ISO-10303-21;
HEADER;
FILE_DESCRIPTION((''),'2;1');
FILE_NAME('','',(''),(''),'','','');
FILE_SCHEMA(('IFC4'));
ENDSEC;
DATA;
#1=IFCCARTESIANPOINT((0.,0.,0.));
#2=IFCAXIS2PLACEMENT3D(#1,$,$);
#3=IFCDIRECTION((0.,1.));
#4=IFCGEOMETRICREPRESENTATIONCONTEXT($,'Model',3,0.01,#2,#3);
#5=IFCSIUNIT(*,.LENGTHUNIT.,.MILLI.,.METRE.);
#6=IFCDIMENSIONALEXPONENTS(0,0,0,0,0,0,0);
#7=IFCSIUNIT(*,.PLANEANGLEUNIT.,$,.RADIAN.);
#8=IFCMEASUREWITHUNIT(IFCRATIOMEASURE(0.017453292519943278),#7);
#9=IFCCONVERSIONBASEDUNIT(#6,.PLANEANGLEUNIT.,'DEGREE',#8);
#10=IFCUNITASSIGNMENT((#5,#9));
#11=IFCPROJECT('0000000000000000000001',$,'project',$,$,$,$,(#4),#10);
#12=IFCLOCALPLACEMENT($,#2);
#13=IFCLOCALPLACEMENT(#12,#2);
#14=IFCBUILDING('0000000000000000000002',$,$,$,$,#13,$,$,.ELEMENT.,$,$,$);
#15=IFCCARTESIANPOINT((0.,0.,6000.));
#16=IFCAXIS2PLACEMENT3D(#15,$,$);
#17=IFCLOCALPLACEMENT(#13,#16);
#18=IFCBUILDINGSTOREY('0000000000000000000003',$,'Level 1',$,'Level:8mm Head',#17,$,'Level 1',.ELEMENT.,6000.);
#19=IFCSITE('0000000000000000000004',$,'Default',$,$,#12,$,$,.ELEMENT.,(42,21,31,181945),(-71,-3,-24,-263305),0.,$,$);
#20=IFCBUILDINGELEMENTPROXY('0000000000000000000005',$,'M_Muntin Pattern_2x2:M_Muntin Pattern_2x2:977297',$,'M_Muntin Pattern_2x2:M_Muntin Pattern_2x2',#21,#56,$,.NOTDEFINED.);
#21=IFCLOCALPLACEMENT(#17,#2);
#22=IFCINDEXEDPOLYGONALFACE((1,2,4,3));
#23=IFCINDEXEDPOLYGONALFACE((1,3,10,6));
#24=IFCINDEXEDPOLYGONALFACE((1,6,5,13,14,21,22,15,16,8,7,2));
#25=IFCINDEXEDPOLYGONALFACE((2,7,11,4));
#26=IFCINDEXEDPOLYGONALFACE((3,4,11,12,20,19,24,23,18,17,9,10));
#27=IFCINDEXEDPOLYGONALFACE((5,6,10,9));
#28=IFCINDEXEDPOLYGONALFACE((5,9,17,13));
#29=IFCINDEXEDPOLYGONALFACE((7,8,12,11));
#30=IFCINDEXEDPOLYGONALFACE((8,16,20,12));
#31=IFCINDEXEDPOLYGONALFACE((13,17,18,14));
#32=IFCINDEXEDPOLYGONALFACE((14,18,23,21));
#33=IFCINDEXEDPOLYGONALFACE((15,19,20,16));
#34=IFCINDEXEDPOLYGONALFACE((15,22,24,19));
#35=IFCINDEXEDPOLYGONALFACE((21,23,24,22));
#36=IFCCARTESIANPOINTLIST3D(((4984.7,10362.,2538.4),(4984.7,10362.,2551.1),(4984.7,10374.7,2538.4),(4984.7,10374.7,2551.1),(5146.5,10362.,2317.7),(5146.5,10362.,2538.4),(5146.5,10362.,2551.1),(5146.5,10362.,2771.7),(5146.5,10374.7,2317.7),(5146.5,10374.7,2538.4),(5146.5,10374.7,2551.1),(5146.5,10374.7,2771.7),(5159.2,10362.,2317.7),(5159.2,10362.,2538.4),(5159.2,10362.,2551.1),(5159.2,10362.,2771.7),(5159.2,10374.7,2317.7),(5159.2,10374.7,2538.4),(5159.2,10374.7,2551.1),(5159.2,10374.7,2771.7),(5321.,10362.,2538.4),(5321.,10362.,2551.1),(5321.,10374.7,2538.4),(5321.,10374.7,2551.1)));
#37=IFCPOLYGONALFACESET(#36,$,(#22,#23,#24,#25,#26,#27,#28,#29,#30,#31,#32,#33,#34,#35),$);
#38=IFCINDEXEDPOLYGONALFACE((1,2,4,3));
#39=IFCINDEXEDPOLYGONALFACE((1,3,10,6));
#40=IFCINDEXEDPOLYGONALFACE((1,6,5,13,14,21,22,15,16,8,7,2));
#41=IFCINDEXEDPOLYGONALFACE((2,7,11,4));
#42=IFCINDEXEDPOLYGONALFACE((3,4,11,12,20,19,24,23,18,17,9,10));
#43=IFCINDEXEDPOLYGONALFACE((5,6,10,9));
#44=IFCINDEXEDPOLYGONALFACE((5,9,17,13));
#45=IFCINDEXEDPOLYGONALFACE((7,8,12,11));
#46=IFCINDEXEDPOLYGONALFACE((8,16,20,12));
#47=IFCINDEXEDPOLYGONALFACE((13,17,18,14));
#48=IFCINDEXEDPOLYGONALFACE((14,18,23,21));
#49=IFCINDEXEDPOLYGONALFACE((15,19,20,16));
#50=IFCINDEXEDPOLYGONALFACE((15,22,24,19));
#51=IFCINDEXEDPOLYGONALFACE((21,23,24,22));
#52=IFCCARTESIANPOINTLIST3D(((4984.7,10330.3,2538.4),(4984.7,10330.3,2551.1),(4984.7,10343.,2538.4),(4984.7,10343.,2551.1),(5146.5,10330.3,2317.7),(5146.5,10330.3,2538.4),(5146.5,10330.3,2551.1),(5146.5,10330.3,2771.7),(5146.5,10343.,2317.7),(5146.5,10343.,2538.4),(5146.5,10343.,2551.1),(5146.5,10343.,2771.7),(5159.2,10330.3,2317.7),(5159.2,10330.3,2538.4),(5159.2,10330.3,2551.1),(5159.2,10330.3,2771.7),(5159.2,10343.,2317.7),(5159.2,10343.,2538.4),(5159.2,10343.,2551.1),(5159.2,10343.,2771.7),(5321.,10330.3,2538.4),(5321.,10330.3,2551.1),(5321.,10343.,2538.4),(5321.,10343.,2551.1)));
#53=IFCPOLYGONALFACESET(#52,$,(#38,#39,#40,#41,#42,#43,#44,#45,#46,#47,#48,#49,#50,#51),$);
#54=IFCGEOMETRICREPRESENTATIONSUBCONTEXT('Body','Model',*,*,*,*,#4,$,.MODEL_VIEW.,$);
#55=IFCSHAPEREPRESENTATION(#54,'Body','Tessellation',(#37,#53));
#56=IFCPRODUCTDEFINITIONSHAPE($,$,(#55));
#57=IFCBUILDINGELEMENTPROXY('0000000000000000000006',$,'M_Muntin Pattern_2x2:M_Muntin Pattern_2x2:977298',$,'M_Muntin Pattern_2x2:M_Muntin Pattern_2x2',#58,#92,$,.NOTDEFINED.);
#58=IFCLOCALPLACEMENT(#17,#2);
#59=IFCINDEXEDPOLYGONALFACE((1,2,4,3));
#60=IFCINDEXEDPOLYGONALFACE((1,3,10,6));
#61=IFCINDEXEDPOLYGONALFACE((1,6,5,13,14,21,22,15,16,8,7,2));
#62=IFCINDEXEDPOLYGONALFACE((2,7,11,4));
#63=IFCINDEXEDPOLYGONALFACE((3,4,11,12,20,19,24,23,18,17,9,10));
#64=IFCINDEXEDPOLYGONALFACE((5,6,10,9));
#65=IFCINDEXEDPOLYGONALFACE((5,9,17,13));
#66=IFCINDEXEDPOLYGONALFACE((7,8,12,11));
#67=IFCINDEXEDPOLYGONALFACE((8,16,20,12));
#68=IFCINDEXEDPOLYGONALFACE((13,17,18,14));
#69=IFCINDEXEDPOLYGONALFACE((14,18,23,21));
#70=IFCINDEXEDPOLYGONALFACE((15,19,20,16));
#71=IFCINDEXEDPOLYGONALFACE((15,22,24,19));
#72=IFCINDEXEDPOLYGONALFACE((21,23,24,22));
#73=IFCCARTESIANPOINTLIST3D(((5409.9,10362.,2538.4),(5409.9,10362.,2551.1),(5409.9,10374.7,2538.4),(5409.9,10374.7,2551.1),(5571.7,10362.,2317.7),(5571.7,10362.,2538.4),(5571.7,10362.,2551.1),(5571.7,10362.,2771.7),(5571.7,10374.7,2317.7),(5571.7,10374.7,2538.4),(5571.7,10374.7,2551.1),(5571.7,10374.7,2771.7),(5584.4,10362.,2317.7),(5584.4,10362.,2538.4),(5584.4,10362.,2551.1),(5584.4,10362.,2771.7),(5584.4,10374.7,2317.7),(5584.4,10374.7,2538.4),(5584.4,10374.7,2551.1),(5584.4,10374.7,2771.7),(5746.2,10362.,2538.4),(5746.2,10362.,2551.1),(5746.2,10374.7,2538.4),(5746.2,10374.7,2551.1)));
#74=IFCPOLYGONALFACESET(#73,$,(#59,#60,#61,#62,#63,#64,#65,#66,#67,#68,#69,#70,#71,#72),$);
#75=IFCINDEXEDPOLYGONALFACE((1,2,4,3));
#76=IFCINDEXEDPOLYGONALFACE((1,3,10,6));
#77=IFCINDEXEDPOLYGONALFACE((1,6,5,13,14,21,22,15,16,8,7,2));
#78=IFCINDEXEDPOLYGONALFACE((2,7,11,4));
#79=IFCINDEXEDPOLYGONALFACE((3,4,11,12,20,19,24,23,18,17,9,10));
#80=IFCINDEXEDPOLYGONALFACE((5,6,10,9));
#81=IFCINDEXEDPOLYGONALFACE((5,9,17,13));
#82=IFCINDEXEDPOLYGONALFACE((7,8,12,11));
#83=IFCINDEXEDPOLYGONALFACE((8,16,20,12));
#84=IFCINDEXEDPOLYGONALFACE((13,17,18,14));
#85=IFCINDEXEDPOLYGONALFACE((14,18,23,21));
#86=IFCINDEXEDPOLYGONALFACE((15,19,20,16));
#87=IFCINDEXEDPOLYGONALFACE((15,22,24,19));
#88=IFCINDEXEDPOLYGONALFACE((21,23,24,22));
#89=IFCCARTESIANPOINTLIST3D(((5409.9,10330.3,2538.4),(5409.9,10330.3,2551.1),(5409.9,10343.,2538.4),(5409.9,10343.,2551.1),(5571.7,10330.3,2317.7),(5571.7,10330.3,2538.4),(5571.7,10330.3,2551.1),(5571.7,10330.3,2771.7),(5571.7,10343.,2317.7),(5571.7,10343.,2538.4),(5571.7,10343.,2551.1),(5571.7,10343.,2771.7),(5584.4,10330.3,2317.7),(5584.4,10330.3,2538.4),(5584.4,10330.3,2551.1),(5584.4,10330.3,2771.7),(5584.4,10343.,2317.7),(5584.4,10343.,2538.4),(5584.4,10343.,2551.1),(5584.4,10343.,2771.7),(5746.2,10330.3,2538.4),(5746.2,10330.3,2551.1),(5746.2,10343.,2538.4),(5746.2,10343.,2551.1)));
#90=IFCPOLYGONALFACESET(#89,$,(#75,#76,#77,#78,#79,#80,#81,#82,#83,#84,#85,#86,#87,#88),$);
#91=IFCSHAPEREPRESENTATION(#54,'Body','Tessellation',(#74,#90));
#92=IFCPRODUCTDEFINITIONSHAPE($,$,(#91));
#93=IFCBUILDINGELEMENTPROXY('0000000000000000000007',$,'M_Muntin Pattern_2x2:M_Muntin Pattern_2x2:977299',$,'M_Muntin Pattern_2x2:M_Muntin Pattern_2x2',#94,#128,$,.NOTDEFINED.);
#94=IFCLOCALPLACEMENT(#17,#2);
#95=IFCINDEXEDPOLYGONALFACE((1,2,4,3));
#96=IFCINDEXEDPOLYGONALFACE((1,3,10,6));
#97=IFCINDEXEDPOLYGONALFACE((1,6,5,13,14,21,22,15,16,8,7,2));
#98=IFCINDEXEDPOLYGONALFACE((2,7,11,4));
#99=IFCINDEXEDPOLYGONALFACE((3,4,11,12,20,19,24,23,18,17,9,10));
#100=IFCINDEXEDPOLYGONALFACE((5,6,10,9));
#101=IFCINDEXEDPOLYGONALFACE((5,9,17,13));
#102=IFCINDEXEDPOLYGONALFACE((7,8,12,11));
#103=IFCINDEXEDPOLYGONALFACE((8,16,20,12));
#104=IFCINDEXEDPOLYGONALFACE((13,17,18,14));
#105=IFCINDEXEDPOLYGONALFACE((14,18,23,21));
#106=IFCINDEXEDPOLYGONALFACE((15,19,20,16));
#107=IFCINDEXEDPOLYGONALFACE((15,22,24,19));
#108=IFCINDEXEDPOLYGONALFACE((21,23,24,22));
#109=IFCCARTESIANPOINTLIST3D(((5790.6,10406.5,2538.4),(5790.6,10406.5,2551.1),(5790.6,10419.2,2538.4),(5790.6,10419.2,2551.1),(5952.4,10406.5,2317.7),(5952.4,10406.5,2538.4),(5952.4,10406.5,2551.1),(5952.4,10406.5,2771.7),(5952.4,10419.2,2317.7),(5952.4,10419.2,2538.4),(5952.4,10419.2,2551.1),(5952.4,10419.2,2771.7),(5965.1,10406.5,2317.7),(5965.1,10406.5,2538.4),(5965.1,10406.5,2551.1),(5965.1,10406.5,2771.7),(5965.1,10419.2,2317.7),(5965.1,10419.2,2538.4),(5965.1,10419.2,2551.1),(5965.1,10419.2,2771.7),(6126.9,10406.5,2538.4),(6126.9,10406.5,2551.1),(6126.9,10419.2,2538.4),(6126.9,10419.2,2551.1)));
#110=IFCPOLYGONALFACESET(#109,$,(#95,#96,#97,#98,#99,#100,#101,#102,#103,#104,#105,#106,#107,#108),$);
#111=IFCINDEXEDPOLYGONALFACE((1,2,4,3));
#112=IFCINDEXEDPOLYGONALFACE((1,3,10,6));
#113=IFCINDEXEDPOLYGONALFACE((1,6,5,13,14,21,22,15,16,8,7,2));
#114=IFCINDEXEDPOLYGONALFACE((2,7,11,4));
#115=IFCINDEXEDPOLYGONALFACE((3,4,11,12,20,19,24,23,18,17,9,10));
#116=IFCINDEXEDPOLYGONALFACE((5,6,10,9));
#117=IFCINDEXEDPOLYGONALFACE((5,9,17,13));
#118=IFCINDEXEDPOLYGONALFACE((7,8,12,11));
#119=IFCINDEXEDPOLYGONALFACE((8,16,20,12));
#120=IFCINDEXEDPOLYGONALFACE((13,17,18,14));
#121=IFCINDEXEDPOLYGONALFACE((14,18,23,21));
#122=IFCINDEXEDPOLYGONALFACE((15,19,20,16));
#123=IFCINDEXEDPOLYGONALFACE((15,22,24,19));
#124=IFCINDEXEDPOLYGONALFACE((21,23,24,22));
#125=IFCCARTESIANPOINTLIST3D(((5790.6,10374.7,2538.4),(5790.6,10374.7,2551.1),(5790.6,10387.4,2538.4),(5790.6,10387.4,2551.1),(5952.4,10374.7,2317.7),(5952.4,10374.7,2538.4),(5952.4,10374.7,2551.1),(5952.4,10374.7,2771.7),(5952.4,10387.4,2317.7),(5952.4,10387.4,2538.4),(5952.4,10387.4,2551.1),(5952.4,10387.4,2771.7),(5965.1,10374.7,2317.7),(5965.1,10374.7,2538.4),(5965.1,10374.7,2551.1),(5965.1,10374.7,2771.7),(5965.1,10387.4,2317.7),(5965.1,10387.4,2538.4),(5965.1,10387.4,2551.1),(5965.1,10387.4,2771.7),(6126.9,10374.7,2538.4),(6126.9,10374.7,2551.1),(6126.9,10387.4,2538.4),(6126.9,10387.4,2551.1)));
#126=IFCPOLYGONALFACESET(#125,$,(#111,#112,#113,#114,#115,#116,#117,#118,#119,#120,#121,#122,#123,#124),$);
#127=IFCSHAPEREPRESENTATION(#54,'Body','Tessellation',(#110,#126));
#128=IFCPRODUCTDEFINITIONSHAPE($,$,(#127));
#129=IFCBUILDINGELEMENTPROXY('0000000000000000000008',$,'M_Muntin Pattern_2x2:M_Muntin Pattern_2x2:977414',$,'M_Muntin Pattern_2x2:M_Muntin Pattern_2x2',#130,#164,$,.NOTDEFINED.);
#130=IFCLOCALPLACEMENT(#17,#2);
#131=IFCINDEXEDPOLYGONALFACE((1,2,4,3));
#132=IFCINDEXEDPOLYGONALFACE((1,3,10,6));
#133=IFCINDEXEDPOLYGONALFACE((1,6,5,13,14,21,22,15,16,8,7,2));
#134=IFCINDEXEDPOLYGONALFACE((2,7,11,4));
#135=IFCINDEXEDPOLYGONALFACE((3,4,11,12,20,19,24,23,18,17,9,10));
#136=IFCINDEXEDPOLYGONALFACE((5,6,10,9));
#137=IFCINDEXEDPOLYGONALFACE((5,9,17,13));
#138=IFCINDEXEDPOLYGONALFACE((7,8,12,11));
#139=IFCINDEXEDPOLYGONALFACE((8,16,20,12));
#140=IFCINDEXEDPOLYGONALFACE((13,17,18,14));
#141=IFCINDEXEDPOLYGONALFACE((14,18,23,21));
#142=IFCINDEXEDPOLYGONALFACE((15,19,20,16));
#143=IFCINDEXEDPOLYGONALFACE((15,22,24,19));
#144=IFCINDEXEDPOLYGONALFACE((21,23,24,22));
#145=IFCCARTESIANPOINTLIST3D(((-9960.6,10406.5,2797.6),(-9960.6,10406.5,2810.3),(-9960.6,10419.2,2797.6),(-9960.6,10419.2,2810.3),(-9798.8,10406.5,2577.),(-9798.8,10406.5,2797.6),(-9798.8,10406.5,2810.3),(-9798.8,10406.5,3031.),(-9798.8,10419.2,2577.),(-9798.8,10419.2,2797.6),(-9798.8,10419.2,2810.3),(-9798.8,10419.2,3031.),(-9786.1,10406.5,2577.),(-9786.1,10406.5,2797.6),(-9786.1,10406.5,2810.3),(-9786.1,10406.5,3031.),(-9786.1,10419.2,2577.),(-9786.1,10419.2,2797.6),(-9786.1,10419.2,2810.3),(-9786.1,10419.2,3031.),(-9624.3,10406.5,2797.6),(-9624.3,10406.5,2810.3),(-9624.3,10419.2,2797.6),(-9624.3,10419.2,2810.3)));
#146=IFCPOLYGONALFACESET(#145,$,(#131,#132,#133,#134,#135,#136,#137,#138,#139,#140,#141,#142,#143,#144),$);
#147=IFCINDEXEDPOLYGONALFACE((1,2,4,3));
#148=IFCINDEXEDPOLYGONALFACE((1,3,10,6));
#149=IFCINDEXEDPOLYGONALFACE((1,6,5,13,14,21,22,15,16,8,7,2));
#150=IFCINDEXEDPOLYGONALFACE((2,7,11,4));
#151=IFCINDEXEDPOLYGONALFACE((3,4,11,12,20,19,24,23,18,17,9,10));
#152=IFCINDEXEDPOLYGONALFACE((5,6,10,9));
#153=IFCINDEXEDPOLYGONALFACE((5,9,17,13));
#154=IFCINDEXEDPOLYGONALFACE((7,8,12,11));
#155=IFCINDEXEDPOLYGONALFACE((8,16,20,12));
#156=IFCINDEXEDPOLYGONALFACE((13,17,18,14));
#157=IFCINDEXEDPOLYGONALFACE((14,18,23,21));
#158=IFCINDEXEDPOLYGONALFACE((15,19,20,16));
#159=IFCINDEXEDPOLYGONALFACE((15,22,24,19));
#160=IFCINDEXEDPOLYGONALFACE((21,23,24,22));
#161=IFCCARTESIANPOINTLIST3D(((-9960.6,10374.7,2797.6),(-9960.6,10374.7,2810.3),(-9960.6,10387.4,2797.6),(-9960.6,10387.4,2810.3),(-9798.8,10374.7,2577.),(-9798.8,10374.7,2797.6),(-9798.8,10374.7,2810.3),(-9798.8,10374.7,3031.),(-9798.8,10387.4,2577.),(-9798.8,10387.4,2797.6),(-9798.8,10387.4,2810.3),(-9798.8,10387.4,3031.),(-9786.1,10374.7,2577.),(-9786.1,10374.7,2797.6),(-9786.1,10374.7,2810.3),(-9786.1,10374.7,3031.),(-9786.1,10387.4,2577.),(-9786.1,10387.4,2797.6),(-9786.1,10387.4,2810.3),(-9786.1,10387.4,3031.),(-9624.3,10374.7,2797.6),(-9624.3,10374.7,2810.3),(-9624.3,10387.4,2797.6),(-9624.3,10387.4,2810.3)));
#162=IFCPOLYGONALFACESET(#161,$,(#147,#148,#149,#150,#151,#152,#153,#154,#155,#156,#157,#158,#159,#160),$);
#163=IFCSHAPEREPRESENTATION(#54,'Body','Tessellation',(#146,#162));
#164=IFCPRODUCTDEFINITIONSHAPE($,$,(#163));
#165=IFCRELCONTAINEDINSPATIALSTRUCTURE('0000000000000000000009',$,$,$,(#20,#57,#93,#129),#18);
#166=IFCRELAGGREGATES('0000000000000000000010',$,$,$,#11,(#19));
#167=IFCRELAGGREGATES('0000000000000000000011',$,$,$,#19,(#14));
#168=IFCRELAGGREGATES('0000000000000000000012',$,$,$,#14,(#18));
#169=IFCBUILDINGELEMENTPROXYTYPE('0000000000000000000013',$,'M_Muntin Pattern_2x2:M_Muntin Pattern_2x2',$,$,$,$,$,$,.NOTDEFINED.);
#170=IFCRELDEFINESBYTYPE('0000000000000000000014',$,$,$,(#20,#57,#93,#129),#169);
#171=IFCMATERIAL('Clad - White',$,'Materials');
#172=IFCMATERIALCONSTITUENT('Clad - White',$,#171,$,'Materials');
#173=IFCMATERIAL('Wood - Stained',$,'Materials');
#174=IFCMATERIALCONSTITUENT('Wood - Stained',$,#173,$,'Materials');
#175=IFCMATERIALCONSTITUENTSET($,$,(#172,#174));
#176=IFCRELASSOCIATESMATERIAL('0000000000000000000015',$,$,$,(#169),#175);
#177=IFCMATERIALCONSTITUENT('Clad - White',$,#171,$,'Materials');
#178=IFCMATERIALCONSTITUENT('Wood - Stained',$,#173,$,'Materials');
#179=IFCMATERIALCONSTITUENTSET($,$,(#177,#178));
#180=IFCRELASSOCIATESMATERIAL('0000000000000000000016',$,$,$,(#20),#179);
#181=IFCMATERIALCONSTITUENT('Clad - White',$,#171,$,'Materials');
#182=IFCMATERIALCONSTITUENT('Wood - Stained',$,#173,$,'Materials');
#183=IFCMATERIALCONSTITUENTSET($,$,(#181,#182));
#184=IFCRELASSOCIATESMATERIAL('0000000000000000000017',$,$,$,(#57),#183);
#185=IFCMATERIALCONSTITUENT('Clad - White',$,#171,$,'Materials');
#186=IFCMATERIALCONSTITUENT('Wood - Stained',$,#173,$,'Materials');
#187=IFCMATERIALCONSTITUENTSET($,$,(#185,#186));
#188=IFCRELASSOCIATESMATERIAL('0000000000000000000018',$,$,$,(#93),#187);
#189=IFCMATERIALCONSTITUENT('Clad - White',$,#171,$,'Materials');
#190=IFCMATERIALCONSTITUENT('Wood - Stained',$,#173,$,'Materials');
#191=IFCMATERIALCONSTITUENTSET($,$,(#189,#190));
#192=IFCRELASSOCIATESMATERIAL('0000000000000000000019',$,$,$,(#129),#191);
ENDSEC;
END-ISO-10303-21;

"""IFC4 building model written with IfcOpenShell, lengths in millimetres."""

from ifc_helpers import new_model, entity, si_unit, converted_unit, direction, frame, origin, place, context, subcontext, project, spatial, polyline, outline, extrude, source, transform, mapped, material, constituent, constituent_set, type_object, type_shapes, element, save


model = new_model("IFC4")

# Units and contexts
model_context = context("Model", 3, precision=0.01, world=origin(), true_north=direction((0.0, 1.0)))
body_context = subcontext(model_context, "Body", "Model", "MODEL_VIEW")
ifc_project = project(units=[si_unit("LENGTHUNIT", "METRE", prefix="MILLI"), converted_unit("PLANEANGLEUNIT", "DEGREE", entity("IfcRatioMeasure", 0.017453292519943278), si_unit("PLANEANGLEUNIT", "RADIAN"), dimensions=[0, 0, 0, 0, 0, 0, 0])], contexts=[model_context])

# Site, building, storey
site_placement = place(None, origin())
site = spatial("IfcSite", under=ifc_project, at=site_placement, Name="Default", CompositionType="ELEMENT", RefLatitude=(42, 21, 31, 181945), RefLongitude=(-71, -3, -24, -263305), RefElevation=0.0)
building_placement = place(site_placement, origin())
building = spatial("IfcBuilding", under=site, at=building_placement, CompositionType="ELEMENT")
storey_placement = place(building_placement, frame((0.0, 0.0, 6000.0)))
storey = spatial("IfcBuildingStorey", under=building, at=storey_placement, Name="Level 1", ObjectType="Level:8mm Head", LongName="Level 1", CompositionType="ELEMENT", Elevation=6000.0)

# Building element proxies
ifc_material_1 = material(Name="Clad - White", Category="Materials")
ifc_material_2 = material(Name="Wood - Stained", Category="Materials")
ifc_constituent_1 = constituent(ifc_material_1, Name="Clad - White", Category="Materials")
ifc_constituent_2 = constituent(ifc_material_2, Name="Wood - Stained", Category="Materials")
ifc_constituent_set_1 = constituent_set(constituents=[ifc_constituent_1, ifc_constituent_2])
building_element_proxy_type_1 = type_object("IfcBuildingElementProxyType", Name="M_Muntin Pattern_2x2:M_Muntin Pattern_2x2", PredefinedType="NOTDEFINED", material=ifc_constituent_set_1)
shared_shape_1 = source(origin(), body_context, "Body", "SweptSolid", [
    extrude(outline(polyline([(6.4, -6.4), (227.0, -6.4), (227.0, 6.3), (6.4, 6.3), (6.4, 168.2), (-6.3, 168.2), (-6.3, 6.3), (-227.0, 6.3), (-227.0, -6.4), (-6.3, -6.4), (-6.3, -168.1), (6.4, -168.1), (6.4, -6.4)])), frame((0.0, 9.5, 227.0), z_axis=(0.0, 1.0, 0.0), x_axis=(0.0, 0.0, 1.0)), (0.0, 0.0, 1.0), 12.7),
    extrude(outline(polyline([(6.4, -6.4), (227.0, -6.4), (227.0, 6.3), (6.4, 6.3), (6.4, 168.2), (-6.3, 168.2), (-6.3, 6.3), (-227.0, 6.3), (-227.0, -6.4), (-6.3, -6.4), (-6.3, -168.1), (6.4, -168.1), (6.4, -6.4)])), frame((0.0, -22.2, 227.0), z_axis=(0.0, 1.0, 0.0), x_axis=(0.0, 0.0, 1.0)), (0.0, 0.0, 1.0), 12.7),
])
type_shapes(building_element_proxy_type_1, [shared_shape_1])
ifc_constituent_3 = constituent(ifc_material_1, Name="Clad - White", Category="Materials")
ifc_constituent_4 = constituent(ifc_material_2, Name="Wood - Stained", Category="Materials")
ifc_constituent_set_2 = constituent_set(constituents=[ifc_constituent_3, ifc_constituent_4])
proxy_1_placement = place(storey_placement, frame((5152.8, 10352.5, 2317.7)))
element("IfcBuildingElementProxy", 1, at=proxy_1_placement, inside=storey, type_object=building_element_proxy_type_1, material=ifc_constituent_set_2, Name="M_Muntin Pattern_2x2:M_Muntin Pattern_2x2:977297", ObjectType="M_Muntin Pattern_2x2:M_Muntin Pattern_2x2", PredefinedType="NOTDEFINED", context=body_context, shape_type="MappedRepresentation", body=[
    mapped(shared_shape_1, transform((0.0, 0.0, 0.0), scale=1.0)),
])
ifc_constituent_5 = constituent(ifc_material_1, Name="Clad - White", Category="Materials")
ifc_constituent_6 = constituent(ifc_material_2, Name="Wood - Stained", Category="Materials")
ifc_constituent_set_3 = constituent_set(constituents=[ifc_constituent_5, ifc_constituent_6])
proxy_2_placement = place(storey_placement, frame((5578.0, 10352.5, 2317.7)))
element("IfcBuildingElementProxy", 2, at=proxy_2_placement, inside=storey, type_object=building_element_proxy_type_1, material=ifc_constituent_set_3, Name="M_Muntin Pattern_2x2:M_Muntin Pattern_2x2:977298", ObjectType="M_Muntin Pattern_2x2:M_Muntin Pattern_2x2", PredefinedType="NOTDEFINED", context=body_context, shape_type="MappedRepresentation", body=[
    mapped(shared_shape_1, transform((0.0, 0.0, 0.0), scale=1.0)),
])
ifc_constituent_7 = constituent(ifc_material_1, Name="Clad - White", Category="Materials")
ifc_constituent_8 = constituent(ifc_material_2, Name="Wood - Stained", Category="Materials")
ifc_constituent_set_4 = constituent_set(constituents=[ifc_constituent_7, ifc_constituent_8])
proxy_3_placement = place(storey_placement, frame((5958.8, 10396.9, 2317.7)))
element("IfcBuildingElementProxy", 3, at=proxy_3_placement, inside=storey, type_object=building_element_proxy_type_1, material=ifc_constituent_set_4, Name="M_Muntin Pattern_2x2:M_Muntin Pattern_2x2:977299", ObjectType="M_Muntin Pattern_2x2:M_Muntin Pattern_2x2", PredefinedType="NOTDEFINED", context=body_context, shape_type="MappedRepresentation", body=[
    mapped(shared_shape_1, transform((0.0, 0.0, 0.0), scale=1.0)),
])
ifc_constituent_9 = constituent(ifc_material_1, Name="Clad - White", Category="Materials")
ifc_constituent_10 = constituent(ifc_material_2, Name="Wood - Stained", Category="Materials")
ifc_constituent_set_5 = constituent_set(constituents=[ifc_constituent_9, ifc_constituent_10])
proxy_4_placement = place(storey_placement, frame((-9792.4, 10396.9, 2577.0)))
element("IfcBuildingElementProxy", 4, at=proxy_4_placement, inside=storey, type_object=building_element_proxy_type_1, material=ifc_constituent_set_5, Name="M_Muntin Pattern_2x2:M_Muntin Pattern_2x2:977414", ObjectType="M_Muntin Pattern_2x2:M_Muntin Pattern_2x2", PredefinedType="NOTDEFINED", context=body_context, shape_type="MappedRepresentation", body=[
    mapped(shared_shape_1, transform((0.0, 0.0, 0.0), scale=1.0)),
])

save(model, "model.ifc")
